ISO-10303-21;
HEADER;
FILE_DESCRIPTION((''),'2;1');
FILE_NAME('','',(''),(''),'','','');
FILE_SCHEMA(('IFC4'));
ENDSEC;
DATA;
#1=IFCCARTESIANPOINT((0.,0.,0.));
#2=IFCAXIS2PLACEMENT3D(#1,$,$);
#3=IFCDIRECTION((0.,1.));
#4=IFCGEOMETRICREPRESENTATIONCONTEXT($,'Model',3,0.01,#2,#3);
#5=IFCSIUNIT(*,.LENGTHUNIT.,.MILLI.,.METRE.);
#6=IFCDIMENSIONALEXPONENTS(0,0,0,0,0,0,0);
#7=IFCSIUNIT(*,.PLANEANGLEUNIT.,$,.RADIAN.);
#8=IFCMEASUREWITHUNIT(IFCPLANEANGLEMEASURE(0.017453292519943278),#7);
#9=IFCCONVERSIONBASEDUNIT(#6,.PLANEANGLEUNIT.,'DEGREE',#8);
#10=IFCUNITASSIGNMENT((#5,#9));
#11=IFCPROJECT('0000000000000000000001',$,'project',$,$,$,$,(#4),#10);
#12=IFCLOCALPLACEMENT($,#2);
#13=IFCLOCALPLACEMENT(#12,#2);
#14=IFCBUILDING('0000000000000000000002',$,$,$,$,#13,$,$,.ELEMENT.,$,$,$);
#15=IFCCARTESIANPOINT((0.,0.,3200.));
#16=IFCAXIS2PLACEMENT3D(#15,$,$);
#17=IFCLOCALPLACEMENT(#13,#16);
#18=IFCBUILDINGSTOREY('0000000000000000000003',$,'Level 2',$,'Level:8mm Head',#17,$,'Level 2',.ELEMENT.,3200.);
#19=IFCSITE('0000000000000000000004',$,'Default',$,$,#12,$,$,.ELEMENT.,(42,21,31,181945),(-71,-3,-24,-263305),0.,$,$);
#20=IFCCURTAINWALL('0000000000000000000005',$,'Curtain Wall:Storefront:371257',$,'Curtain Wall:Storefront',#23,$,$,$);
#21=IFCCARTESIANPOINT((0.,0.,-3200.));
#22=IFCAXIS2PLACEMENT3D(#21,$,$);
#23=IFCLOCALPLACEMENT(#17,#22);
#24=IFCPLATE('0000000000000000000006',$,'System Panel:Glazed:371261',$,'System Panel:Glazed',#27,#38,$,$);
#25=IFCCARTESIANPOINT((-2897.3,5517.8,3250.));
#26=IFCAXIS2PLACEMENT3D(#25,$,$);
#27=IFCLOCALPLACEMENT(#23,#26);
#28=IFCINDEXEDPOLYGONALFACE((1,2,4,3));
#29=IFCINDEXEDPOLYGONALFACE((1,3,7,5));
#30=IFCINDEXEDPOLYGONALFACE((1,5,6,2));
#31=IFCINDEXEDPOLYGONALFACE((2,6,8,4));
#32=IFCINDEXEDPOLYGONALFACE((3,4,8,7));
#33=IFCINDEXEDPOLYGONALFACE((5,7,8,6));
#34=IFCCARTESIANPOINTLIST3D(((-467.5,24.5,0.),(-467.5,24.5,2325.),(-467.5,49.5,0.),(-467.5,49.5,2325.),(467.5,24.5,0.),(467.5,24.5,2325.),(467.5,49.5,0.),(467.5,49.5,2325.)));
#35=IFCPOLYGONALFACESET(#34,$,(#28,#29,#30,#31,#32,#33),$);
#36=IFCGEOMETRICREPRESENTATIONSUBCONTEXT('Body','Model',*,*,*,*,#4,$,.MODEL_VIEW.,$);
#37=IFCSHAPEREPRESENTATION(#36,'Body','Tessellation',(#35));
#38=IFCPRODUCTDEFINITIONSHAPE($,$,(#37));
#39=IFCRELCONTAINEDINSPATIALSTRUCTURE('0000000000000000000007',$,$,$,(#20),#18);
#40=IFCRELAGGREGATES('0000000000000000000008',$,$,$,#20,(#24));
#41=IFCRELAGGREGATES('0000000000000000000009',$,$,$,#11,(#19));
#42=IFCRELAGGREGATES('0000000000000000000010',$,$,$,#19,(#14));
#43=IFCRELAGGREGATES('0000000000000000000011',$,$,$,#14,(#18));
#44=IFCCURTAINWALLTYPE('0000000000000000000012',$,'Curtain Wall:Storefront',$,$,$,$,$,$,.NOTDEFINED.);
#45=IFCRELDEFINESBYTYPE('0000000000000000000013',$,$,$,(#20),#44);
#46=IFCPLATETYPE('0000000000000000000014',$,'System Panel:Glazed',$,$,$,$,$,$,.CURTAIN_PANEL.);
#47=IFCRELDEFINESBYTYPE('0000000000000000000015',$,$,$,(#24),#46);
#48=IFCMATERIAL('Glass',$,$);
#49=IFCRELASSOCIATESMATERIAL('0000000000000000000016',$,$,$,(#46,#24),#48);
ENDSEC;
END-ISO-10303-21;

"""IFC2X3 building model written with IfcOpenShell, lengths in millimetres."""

from ifc_helpers import new_model, entity, si_unit, converted_unit, direction, frame, origin, origin_2d_with_axis, place, context, subcontext, project, spatial, rectangle, extrude, source, transform, mapped, material, type_object, type_shapes, element, aggregate, save


model = new_model("IFC2X3")

# Units and contexts
model_context = context("Model", 3, precision=0.01, world=origin(), true_north=direction((0.0, 1.0)))
body_context = subcontext(model_context, "Body", "Model", "MODEL_VIEW")
ifc_project = project(units=[si_unit("LENGTHUNIT", "METRE", prefix="MILLI"), converted_unit("PLANEANGLEUNIT", "DEGREE", entity("IfcPlaneAngleMeasure", 0.017453292519943278), si_unit("PLANEANGLEUNIT", "RADIAN"), dimensions=[0, 0, 0, 0, 0, 0, 0])], contexts=[model_context])

# Site, building, storey
site_placement = place(None, origin())
site = spatial("IfcSite", under=ifc_project, at=site_placement, Name="Default", CompositionType="ELEMENT", RefLatitude=(42, 21, 31, 181945), RefLongitude=(-71, -3, -24, -263305), RefElevation=0.0)
building_placement = place(site_placement, origin())
building = spatial("IfcBuilding", under=site, at=building_placement, CompositionType="ELEMENT")
storey_placement = place(building_placement, frame((0.0, 0.0, 3200.0)))
storey = spatial("IfcBuildingStorey", under=building, at=storey_placement, Name="Level 2", ObjectType="Level:8mm Head", LongName="Level 2", CompositionType="ELEMENT", Elevation=3200.0)

# Curtain wall
curtain_wall_type = type_object("IfcCurtainWallType", Name="Curtain Wall:Storefront", PredefinedType="NOTDEFINED")
curtain_wall_1_placement = place(storey_placement, frame((0.0, 0.0, -3200.0)))
curtain_wall_1 = element("IfcCurtainWall", 1, at=curtain_wall_1_placement, inside=storey, type_object=curtain_wall_type, Name="Curtain Wall:Storefront:371257", ObjectType="Curtain Wall:Storefront")

# Plate
ifc_material_1 = material(Name="Glass")
plate_type_1 = type_object("IfcPlateType", Name="System Panel:Glazed", PredefinedType="CURTAIN_PANEL", material=ifc_material_1)
shared_shape_1 = source(origin(), body_context, "Body", "SweptSolid", [
    extrude(rectangle(XDim=25.0, YDim=935.0, at=origin_2d_with_axis()), frame((0.0, 37.0, 0.0), z_axis=(0.0, 0.0, 1.0), x_axis=(0.0, 1.0, 0.0)), (0.0, 0.0, 1.0), 2325.0),
])
type_shapes(plate_type_1, [shared_shape_1])
plate_1_placement = place(curtain_wall_1_placement, frame((-2897.3, 5517.8, 3250.0)))
plate_1 = element("IfcPlate", 2, at=plate_1_placement, type_object=plate_type_1, material=ifc_material_1, Name="System Panel:Glazed:371261", ObjectType="System Panel:Glazed", context=body_context, shape_type="MappedRepresentation", body=[
    mapped(shared_shape_1, transform((0.0, 0.0, 0.0), scale=1.0)),
])
aggregate(curtain_wall_1, [plate_1])

save(model, "model.ifc")
